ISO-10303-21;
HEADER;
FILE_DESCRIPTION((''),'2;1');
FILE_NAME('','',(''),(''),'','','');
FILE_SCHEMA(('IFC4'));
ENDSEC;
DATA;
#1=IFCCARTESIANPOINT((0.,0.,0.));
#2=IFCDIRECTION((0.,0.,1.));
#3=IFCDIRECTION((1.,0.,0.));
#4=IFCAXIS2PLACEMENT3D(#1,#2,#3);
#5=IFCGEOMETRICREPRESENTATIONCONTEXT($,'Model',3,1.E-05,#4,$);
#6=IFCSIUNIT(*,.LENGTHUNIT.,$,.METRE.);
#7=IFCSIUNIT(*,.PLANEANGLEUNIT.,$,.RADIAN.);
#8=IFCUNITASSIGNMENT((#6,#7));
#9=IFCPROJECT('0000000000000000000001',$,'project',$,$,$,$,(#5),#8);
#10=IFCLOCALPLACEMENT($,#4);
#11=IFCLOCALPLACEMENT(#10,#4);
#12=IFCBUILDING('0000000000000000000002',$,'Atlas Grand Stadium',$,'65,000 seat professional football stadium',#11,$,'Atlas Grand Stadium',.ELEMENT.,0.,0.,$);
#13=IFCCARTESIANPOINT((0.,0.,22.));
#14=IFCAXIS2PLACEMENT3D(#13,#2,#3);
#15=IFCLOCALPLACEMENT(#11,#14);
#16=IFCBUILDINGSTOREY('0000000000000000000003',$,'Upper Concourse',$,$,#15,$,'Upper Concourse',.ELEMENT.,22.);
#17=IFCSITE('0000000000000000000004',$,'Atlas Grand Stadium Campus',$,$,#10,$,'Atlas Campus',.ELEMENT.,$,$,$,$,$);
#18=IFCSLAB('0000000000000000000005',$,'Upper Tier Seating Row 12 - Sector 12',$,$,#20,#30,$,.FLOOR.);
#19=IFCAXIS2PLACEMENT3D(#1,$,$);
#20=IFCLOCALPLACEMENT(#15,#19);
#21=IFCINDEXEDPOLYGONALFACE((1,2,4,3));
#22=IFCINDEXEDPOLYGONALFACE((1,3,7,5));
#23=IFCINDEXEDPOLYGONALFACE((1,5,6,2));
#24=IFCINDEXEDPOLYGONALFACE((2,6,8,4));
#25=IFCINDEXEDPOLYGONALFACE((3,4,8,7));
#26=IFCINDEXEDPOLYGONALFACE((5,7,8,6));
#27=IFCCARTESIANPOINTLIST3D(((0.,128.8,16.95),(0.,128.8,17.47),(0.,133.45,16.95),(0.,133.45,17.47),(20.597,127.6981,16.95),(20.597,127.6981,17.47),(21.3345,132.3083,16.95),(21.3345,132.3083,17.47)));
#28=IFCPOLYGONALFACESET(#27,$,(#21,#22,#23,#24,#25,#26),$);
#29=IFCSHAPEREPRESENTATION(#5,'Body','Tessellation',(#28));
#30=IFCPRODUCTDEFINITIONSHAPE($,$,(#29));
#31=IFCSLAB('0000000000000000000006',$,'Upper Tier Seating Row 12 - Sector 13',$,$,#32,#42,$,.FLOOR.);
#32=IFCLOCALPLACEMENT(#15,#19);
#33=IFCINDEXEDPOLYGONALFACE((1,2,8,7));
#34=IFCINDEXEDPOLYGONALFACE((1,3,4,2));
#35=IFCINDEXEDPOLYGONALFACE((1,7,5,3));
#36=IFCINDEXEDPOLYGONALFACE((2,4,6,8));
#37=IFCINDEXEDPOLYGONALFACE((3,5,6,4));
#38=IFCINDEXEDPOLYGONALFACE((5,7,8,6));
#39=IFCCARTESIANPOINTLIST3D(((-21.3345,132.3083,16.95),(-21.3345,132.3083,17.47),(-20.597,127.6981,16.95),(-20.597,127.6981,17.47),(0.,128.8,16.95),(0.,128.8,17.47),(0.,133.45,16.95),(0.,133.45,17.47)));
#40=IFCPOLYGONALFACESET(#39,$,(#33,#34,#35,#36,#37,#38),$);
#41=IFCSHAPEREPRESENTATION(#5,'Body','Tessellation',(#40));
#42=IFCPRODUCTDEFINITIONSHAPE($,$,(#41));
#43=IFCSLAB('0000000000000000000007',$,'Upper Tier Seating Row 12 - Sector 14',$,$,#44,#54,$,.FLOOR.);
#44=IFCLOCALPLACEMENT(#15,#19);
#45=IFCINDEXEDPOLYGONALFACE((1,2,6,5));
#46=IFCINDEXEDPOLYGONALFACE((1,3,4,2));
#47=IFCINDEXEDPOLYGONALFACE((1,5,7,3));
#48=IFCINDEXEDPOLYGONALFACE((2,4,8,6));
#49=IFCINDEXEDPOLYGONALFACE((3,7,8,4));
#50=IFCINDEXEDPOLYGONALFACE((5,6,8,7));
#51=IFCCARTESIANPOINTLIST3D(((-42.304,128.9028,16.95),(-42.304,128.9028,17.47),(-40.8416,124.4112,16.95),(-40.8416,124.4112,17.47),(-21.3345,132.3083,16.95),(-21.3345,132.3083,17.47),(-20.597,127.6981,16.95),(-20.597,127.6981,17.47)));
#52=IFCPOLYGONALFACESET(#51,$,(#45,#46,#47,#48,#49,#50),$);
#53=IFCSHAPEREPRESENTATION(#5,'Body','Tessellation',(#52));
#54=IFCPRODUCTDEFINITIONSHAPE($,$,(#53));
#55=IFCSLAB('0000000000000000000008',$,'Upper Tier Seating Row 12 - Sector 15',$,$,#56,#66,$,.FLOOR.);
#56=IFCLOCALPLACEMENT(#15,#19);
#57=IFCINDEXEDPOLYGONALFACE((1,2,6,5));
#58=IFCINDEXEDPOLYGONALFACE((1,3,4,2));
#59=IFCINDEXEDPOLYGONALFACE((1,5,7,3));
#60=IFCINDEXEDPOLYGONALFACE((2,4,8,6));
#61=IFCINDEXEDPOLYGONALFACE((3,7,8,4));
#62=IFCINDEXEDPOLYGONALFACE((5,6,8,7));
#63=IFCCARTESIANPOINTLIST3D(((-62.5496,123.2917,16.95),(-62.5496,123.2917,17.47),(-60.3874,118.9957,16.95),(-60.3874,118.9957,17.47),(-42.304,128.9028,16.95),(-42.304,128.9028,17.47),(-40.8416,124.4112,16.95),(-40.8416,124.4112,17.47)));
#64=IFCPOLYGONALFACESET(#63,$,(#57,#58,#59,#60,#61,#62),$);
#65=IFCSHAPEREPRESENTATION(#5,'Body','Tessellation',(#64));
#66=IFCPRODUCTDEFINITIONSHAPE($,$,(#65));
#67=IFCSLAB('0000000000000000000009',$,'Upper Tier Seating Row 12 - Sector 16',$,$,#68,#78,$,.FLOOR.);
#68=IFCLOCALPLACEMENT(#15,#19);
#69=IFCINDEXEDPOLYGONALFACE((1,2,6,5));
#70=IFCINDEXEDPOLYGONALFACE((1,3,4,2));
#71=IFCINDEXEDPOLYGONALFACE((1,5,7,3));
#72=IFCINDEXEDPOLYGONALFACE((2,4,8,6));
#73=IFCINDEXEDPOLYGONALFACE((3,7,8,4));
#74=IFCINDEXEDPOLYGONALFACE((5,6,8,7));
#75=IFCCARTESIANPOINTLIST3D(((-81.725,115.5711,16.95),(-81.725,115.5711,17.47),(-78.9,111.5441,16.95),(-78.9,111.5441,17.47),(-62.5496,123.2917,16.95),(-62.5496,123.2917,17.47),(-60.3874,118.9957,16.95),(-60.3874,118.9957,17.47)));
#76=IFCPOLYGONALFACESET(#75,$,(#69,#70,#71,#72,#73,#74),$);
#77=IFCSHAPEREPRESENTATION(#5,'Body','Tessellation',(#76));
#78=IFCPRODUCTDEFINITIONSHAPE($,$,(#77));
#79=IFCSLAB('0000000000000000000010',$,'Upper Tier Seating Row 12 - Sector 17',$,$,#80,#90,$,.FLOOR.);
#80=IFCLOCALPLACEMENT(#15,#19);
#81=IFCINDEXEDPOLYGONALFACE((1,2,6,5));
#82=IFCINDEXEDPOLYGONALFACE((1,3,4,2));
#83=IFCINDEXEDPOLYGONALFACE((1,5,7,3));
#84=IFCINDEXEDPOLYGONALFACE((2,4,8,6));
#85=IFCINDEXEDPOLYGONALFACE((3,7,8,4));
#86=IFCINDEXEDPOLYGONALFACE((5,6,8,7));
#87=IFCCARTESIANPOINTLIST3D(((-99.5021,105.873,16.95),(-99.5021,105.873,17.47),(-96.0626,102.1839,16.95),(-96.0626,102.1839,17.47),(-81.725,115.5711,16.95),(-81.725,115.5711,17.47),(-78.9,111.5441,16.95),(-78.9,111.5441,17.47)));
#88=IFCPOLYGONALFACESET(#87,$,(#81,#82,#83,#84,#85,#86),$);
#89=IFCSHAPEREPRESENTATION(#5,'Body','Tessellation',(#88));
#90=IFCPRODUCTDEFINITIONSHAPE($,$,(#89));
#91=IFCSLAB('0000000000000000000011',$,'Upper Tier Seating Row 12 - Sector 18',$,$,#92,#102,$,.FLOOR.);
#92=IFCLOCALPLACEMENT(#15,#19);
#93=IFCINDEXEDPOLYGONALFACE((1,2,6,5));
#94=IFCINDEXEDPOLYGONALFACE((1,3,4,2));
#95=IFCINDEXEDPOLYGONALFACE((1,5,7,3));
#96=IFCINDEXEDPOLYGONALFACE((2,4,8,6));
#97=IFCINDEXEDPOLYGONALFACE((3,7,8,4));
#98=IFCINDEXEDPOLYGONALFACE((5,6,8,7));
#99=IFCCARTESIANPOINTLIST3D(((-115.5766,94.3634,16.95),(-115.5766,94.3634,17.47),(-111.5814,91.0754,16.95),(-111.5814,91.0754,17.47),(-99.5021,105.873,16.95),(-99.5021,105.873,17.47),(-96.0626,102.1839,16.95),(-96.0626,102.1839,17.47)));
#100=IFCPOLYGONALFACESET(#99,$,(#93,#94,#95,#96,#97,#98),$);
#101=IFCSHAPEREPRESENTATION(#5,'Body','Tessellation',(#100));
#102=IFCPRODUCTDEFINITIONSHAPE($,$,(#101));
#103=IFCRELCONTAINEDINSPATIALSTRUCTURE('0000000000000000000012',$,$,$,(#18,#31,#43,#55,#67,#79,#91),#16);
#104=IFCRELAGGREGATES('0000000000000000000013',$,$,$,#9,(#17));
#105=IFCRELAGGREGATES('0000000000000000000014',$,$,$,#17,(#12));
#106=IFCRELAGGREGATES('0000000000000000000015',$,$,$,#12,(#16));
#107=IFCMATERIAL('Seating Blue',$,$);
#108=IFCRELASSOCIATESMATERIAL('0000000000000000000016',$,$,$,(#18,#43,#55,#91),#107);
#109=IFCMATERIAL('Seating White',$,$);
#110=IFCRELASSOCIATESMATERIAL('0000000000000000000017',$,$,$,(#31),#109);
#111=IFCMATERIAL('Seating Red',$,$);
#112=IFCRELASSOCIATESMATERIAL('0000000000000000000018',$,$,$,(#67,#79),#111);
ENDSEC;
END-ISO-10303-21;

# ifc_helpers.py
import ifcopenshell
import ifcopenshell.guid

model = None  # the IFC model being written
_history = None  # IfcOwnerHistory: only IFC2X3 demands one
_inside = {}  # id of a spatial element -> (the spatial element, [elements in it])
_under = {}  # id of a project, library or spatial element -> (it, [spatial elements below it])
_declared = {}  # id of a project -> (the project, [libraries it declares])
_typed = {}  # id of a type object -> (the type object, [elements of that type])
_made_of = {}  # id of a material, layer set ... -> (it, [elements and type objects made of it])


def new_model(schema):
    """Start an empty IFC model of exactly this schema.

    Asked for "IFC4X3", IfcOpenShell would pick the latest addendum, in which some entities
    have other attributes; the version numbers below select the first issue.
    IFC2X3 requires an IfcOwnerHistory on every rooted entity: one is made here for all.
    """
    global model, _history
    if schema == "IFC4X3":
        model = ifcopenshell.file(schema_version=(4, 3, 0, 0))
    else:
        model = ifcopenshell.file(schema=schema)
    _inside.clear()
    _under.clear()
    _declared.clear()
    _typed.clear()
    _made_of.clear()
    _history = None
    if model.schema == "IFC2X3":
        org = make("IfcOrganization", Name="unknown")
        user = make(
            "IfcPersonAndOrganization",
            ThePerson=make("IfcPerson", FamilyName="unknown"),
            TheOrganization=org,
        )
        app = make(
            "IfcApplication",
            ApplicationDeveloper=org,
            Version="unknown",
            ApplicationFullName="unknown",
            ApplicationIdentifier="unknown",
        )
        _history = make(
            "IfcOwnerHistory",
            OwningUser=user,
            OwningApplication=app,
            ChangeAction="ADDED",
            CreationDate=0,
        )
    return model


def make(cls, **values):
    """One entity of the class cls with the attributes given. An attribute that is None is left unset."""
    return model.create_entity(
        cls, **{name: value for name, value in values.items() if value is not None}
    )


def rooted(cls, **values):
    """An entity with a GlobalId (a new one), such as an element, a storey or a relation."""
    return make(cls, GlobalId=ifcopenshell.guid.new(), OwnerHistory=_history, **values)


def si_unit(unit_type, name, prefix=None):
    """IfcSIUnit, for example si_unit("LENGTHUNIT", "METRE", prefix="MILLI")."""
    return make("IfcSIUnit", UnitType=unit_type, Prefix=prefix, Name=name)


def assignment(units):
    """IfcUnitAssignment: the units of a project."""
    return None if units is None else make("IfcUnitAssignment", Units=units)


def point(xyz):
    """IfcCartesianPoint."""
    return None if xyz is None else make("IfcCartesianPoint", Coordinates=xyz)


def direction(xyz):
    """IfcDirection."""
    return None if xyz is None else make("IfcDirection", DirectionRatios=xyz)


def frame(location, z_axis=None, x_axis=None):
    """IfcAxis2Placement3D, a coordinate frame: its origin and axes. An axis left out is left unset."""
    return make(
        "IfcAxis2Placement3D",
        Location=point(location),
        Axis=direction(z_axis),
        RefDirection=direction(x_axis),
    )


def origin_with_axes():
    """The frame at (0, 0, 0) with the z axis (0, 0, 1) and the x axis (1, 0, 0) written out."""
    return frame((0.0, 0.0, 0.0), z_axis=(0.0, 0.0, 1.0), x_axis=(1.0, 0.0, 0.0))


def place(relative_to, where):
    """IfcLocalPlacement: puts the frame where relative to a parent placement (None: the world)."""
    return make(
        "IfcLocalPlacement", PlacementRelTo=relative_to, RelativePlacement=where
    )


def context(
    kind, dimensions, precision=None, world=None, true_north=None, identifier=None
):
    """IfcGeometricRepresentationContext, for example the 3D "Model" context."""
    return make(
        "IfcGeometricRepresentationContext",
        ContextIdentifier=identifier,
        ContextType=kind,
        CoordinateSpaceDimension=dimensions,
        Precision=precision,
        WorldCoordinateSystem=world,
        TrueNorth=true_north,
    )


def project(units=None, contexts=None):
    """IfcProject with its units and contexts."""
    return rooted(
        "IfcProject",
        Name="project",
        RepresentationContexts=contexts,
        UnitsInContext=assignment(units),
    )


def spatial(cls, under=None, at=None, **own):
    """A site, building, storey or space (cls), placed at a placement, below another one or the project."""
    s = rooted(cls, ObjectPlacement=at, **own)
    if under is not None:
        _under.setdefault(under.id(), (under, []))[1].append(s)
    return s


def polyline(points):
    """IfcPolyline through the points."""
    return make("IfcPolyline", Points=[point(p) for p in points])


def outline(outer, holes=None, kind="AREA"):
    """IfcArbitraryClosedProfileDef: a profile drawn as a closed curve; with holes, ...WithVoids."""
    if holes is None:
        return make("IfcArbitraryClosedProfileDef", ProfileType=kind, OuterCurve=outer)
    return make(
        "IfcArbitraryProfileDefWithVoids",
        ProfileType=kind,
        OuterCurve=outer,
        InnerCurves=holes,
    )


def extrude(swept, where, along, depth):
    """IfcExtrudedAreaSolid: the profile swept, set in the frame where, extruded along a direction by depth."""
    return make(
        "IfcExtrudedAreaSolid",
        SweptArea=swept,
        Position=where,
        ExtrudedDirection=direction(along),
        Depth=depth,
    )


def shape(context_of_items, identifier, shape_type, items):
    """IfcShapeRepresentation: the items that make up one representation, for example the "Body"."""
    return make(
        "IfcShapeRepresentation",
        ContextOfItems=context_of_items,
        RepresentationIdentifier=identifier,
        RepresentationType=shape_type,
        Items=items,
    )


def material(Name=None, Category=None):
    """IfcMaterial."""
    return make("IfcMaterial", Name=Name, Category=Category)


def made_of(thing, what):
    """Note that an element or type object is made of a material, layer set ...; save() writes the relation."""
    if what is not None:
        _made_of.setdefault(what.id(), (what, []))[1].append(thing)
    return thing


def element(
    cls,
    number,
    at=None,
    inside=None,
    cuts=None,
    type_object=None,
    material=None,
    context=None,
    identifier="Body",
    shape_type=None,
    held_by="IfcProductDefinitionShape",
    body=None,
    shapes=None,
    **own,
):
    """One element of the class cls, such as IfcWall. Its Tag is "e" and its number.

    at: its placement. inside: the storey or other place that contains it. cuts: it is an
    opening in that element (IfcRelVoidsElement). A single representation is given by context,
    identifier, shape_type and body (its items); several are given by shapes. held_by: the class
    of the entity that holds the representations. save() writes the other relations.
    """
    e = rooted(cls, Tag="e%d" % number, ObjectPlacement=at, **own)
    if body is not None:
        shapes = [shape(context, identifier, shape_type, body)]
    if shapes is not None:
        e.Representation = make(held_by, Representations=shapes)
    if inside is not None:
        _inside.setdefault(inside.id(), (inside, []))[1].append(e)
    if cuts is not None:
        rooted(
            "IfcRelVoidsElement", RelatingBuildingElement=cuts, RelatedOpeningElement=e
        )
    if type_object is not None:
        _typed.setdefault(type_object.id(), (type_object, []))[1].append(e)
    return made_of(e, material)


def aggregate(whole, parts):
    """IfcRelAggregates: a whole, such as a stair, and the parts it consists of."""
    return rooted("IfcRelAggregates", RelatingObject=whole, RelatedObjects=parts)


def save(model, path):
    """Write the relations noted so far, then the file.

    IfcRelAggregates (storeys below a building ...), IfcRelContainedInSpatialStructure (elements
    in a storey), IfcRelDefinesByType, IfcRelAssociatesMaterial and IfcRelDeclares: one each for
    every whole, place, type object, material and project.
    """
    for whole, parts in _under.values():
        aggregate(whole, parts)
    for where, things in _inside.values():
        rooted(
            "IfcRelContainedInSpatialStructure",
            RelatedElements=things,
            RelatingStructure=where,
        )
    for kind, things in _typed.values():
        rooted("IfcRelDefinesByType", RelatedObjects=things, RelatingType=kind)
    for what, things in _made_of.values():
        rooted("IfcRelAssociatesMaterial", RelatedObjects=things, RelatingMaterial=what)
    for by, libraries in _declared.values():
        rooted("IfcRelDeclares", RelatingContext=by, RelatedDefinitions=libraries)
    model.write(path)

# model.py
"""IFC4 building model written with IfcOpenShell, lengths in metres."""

from ifc_helpers import new_model, si_unit, frame, origin_with_axes, place, context, project, spatial, polyline, outline, extrude, material, element, save


model = new_model("IFC4")

# Units and contexts
model_context = context("Model", 3, precision=1e-05, world=origin_with_axes())
ifc_project = project(units=[si_unit("LENGTHUNIT", "METRE"), si_unit("PLANEANGLEUNIT", "RADIAN")], contexts=[model_context])

# Site, building, storey
site_placement = place(None, origin_with_axes())
site = spatial("IfcSite", under=ifc_project, at=site_placement, Name="Atlas Grand Stadium Campus", LongName="Atlas Campus", CompositionType="ELEMENT")
building_placement = place(site_placement, origin_with_axes())
building = spatial("IfcBuilding", under=site, at=building_placement, Name="Atlas Grand Stadium", ObjectType="65,000 seat professional football stadium", LongName="Atlas Grand Stadium", CompositionType="ELEMENT", ElevationOfRefHeight=0.0, ElevationOfTerrain=0.0)
storey_placement = place(building_placement, frame((0.0, 0.0, 22.0), z_axis=(0.0, 0.0, 1.0), x_axis=(1.0, 0.0, 0.0)))
storey = spatial("IfcBuildingStorey", under=building, at=storey_placement, Name="Upper Concourse", LongName="Upper Concourse", CompositionType="ELEMENT", Elevation=22.0)

# Slabs
ifc_material_1 = material(Name="Seating Blue")
ifc_material_2 = material(Name="Seating White")
ifc_material_3 = material(Name="Seating Red")
slab_1_placement = place(storey_placement, frame((0.0, 0.0, 16.95), z_axis=(0.0, 0.0, 1.0), x_axis=(1.0, 0.0, 0.0)))
element("IfcSlab", 1, at=slab_1_placement, inside=storey, material=ifc_material_1, Name="Upper Tier Seating Row 12 - Sector 12", PredefinedType="FLOOR", context=model_context, shape_type="SweptSolid", body=[
    extrude(outline(polyline([(21.3345, 132.3083), (0.0, 133.45), (0.0, 128.8), (20.597, 127.6981), (21.3345, 132.3083)])), origin_with_axes(), (0.0, 0.0, 1.0), 0.52),
])
slab_2_placement = place(storey_placement, frame((0.0, 0.0, 16.95), z_axis=(0.0, 0.0, 1.0), x_axis=(1.0, 0.0, 0.0)))
element("IfcSlab", 2, at=slab_2_placement, inside=storey, material=ifc_material_2, Name="Upper Tier Seating Row 12 - Sector 13", PredefinedType="FLOOR", context=model_context, shape_type="SweptSolid", body=[
    extrude(outline(polyline([(0.0, 133.45), (-21.3345, 132.3083), (-20.597, 127.6981), (0.0, 128.8), (0.0, 133.45)])), origin_with_axes(), (0.0, 0.0, 1.0), 0.52),
])
slab_3_placement = place(storey_placement, frame((0.0, 0.0, 16.95), z_axis=(0.0, 0.0, 1.0), x_axis=(1.0, 0.0, 0.0)))
element("IfcSlab", 3, at=slab_3_placement, inside=storey, material=ifc_material_1, Name="Upper Tier Seating Row 12 - Sector 14", PredefinedType="FLOOR", context=model_context, shape_type="SweptSolid", body=[
    extrude(outline(polyline([(-21.3345, 132.3083), (-42.304, 128.9028), (-40.8417, 124.4112), (-20.597, 127.6981), (-21.3345, 132.3083)])), origin_with_axes(), (0.0, 0.0, 1.0), 0.52),
])
slab_4_placement = place(storey_placement, frame((0.0, 0.0, 16.95), z_axis=(0.0, 0.0, 1.0), x_axis=(1.0, 0.0, 0.0)))
element("IfcSlab", 4, at=slab_4_placement, inside=storey, material=ifc_material_1, Name="Upper Tier Seating Row 12 - Sector 15", PredefinedType="FLOOR", context=model_context, shape_type="SweptSolid", body=[
    extrude(outline(polyline([(-42.304, 128.9028), (-62.5496, 123.2917), (-60.3875, 118.9957), (-40.8417, 124.4112), (-42.304, 128.9028)])), origin_with_axes(), (0.0, 0.0, 1.0), 0.52),
])
slab_5_placement = place(storey_placement, frame((0.0, 0.0, 16.95), z_axis=(0.0, 0.0, 1.0), x_axis=(1.0, 0.0, 0.0)))
element("IfcSlab", 5, at=slab_5_placement, inside=storey, material=ifc_material_3, Name="Upper Tier Seating Row 12 - Sector 16", PredefinedType="FLOOR", context=model_context, shape_type="SweptSolid", body=[
    extrude(outline(polyline([(-62.5496, 123.2917), (-81.725, 115.5711), (-78.9, 111.5441), (-60.3875, 118.9957), (-62.5496, 123.2917)])), origin_with_axes(), (0.0, 0.0, 1.0), 0.52),
])
slab_6_placement = place(storey_placement, frame((0.0, 0.0, 16.95), z_axis=(0.0, 0.0, 1.0), x_axis=(1.0, 0.0, 0.0)))
element("IfcSlab", 6, at=slab_6_placement, inside=storey, material=ifc_material_3, Name="Upper Tier Seating Row 12 - Sector 17", PredefinedType="FLOOR", context=model_context, shape_type="SweptSolid", body=[
    extrude(outline(polyline([(-81.725, 115.5711), (-99.5021, 105.873), (-96.0626, 102.1839), (-78.9, 111.5441), (-81.725, 115.5711)])), origin_with_axes(), (0.0, 0.0, 1.0), 0.52),
])
slab_7_placement = place(storey_placement, frame((0.0, 0.0, 16.95), z_axis=(0.0, 0.0, 1.0), x_axis=(1.0, 0.0, 0.0)))
element("IfcSlab", 7, at=slab_7_placement, inside=storey, material=ifc_material_1, Name="Upper Tier Seating Row 12 - Sector 18", PredefinedType="FLOOR", context=model_context, shape_type="SweptSolid", body=[
    extrude(outline(polyline([(-99.5021, 105.873), (-115.5766, 94.3634), (-111.5815, 91.0754), (-96.0626, 102.1839), (-99.5021, 105.873)])), origin_with_axes(), (0.0, 0.0, 1.0), 0.52),
])

save(model, "model.ifc")
